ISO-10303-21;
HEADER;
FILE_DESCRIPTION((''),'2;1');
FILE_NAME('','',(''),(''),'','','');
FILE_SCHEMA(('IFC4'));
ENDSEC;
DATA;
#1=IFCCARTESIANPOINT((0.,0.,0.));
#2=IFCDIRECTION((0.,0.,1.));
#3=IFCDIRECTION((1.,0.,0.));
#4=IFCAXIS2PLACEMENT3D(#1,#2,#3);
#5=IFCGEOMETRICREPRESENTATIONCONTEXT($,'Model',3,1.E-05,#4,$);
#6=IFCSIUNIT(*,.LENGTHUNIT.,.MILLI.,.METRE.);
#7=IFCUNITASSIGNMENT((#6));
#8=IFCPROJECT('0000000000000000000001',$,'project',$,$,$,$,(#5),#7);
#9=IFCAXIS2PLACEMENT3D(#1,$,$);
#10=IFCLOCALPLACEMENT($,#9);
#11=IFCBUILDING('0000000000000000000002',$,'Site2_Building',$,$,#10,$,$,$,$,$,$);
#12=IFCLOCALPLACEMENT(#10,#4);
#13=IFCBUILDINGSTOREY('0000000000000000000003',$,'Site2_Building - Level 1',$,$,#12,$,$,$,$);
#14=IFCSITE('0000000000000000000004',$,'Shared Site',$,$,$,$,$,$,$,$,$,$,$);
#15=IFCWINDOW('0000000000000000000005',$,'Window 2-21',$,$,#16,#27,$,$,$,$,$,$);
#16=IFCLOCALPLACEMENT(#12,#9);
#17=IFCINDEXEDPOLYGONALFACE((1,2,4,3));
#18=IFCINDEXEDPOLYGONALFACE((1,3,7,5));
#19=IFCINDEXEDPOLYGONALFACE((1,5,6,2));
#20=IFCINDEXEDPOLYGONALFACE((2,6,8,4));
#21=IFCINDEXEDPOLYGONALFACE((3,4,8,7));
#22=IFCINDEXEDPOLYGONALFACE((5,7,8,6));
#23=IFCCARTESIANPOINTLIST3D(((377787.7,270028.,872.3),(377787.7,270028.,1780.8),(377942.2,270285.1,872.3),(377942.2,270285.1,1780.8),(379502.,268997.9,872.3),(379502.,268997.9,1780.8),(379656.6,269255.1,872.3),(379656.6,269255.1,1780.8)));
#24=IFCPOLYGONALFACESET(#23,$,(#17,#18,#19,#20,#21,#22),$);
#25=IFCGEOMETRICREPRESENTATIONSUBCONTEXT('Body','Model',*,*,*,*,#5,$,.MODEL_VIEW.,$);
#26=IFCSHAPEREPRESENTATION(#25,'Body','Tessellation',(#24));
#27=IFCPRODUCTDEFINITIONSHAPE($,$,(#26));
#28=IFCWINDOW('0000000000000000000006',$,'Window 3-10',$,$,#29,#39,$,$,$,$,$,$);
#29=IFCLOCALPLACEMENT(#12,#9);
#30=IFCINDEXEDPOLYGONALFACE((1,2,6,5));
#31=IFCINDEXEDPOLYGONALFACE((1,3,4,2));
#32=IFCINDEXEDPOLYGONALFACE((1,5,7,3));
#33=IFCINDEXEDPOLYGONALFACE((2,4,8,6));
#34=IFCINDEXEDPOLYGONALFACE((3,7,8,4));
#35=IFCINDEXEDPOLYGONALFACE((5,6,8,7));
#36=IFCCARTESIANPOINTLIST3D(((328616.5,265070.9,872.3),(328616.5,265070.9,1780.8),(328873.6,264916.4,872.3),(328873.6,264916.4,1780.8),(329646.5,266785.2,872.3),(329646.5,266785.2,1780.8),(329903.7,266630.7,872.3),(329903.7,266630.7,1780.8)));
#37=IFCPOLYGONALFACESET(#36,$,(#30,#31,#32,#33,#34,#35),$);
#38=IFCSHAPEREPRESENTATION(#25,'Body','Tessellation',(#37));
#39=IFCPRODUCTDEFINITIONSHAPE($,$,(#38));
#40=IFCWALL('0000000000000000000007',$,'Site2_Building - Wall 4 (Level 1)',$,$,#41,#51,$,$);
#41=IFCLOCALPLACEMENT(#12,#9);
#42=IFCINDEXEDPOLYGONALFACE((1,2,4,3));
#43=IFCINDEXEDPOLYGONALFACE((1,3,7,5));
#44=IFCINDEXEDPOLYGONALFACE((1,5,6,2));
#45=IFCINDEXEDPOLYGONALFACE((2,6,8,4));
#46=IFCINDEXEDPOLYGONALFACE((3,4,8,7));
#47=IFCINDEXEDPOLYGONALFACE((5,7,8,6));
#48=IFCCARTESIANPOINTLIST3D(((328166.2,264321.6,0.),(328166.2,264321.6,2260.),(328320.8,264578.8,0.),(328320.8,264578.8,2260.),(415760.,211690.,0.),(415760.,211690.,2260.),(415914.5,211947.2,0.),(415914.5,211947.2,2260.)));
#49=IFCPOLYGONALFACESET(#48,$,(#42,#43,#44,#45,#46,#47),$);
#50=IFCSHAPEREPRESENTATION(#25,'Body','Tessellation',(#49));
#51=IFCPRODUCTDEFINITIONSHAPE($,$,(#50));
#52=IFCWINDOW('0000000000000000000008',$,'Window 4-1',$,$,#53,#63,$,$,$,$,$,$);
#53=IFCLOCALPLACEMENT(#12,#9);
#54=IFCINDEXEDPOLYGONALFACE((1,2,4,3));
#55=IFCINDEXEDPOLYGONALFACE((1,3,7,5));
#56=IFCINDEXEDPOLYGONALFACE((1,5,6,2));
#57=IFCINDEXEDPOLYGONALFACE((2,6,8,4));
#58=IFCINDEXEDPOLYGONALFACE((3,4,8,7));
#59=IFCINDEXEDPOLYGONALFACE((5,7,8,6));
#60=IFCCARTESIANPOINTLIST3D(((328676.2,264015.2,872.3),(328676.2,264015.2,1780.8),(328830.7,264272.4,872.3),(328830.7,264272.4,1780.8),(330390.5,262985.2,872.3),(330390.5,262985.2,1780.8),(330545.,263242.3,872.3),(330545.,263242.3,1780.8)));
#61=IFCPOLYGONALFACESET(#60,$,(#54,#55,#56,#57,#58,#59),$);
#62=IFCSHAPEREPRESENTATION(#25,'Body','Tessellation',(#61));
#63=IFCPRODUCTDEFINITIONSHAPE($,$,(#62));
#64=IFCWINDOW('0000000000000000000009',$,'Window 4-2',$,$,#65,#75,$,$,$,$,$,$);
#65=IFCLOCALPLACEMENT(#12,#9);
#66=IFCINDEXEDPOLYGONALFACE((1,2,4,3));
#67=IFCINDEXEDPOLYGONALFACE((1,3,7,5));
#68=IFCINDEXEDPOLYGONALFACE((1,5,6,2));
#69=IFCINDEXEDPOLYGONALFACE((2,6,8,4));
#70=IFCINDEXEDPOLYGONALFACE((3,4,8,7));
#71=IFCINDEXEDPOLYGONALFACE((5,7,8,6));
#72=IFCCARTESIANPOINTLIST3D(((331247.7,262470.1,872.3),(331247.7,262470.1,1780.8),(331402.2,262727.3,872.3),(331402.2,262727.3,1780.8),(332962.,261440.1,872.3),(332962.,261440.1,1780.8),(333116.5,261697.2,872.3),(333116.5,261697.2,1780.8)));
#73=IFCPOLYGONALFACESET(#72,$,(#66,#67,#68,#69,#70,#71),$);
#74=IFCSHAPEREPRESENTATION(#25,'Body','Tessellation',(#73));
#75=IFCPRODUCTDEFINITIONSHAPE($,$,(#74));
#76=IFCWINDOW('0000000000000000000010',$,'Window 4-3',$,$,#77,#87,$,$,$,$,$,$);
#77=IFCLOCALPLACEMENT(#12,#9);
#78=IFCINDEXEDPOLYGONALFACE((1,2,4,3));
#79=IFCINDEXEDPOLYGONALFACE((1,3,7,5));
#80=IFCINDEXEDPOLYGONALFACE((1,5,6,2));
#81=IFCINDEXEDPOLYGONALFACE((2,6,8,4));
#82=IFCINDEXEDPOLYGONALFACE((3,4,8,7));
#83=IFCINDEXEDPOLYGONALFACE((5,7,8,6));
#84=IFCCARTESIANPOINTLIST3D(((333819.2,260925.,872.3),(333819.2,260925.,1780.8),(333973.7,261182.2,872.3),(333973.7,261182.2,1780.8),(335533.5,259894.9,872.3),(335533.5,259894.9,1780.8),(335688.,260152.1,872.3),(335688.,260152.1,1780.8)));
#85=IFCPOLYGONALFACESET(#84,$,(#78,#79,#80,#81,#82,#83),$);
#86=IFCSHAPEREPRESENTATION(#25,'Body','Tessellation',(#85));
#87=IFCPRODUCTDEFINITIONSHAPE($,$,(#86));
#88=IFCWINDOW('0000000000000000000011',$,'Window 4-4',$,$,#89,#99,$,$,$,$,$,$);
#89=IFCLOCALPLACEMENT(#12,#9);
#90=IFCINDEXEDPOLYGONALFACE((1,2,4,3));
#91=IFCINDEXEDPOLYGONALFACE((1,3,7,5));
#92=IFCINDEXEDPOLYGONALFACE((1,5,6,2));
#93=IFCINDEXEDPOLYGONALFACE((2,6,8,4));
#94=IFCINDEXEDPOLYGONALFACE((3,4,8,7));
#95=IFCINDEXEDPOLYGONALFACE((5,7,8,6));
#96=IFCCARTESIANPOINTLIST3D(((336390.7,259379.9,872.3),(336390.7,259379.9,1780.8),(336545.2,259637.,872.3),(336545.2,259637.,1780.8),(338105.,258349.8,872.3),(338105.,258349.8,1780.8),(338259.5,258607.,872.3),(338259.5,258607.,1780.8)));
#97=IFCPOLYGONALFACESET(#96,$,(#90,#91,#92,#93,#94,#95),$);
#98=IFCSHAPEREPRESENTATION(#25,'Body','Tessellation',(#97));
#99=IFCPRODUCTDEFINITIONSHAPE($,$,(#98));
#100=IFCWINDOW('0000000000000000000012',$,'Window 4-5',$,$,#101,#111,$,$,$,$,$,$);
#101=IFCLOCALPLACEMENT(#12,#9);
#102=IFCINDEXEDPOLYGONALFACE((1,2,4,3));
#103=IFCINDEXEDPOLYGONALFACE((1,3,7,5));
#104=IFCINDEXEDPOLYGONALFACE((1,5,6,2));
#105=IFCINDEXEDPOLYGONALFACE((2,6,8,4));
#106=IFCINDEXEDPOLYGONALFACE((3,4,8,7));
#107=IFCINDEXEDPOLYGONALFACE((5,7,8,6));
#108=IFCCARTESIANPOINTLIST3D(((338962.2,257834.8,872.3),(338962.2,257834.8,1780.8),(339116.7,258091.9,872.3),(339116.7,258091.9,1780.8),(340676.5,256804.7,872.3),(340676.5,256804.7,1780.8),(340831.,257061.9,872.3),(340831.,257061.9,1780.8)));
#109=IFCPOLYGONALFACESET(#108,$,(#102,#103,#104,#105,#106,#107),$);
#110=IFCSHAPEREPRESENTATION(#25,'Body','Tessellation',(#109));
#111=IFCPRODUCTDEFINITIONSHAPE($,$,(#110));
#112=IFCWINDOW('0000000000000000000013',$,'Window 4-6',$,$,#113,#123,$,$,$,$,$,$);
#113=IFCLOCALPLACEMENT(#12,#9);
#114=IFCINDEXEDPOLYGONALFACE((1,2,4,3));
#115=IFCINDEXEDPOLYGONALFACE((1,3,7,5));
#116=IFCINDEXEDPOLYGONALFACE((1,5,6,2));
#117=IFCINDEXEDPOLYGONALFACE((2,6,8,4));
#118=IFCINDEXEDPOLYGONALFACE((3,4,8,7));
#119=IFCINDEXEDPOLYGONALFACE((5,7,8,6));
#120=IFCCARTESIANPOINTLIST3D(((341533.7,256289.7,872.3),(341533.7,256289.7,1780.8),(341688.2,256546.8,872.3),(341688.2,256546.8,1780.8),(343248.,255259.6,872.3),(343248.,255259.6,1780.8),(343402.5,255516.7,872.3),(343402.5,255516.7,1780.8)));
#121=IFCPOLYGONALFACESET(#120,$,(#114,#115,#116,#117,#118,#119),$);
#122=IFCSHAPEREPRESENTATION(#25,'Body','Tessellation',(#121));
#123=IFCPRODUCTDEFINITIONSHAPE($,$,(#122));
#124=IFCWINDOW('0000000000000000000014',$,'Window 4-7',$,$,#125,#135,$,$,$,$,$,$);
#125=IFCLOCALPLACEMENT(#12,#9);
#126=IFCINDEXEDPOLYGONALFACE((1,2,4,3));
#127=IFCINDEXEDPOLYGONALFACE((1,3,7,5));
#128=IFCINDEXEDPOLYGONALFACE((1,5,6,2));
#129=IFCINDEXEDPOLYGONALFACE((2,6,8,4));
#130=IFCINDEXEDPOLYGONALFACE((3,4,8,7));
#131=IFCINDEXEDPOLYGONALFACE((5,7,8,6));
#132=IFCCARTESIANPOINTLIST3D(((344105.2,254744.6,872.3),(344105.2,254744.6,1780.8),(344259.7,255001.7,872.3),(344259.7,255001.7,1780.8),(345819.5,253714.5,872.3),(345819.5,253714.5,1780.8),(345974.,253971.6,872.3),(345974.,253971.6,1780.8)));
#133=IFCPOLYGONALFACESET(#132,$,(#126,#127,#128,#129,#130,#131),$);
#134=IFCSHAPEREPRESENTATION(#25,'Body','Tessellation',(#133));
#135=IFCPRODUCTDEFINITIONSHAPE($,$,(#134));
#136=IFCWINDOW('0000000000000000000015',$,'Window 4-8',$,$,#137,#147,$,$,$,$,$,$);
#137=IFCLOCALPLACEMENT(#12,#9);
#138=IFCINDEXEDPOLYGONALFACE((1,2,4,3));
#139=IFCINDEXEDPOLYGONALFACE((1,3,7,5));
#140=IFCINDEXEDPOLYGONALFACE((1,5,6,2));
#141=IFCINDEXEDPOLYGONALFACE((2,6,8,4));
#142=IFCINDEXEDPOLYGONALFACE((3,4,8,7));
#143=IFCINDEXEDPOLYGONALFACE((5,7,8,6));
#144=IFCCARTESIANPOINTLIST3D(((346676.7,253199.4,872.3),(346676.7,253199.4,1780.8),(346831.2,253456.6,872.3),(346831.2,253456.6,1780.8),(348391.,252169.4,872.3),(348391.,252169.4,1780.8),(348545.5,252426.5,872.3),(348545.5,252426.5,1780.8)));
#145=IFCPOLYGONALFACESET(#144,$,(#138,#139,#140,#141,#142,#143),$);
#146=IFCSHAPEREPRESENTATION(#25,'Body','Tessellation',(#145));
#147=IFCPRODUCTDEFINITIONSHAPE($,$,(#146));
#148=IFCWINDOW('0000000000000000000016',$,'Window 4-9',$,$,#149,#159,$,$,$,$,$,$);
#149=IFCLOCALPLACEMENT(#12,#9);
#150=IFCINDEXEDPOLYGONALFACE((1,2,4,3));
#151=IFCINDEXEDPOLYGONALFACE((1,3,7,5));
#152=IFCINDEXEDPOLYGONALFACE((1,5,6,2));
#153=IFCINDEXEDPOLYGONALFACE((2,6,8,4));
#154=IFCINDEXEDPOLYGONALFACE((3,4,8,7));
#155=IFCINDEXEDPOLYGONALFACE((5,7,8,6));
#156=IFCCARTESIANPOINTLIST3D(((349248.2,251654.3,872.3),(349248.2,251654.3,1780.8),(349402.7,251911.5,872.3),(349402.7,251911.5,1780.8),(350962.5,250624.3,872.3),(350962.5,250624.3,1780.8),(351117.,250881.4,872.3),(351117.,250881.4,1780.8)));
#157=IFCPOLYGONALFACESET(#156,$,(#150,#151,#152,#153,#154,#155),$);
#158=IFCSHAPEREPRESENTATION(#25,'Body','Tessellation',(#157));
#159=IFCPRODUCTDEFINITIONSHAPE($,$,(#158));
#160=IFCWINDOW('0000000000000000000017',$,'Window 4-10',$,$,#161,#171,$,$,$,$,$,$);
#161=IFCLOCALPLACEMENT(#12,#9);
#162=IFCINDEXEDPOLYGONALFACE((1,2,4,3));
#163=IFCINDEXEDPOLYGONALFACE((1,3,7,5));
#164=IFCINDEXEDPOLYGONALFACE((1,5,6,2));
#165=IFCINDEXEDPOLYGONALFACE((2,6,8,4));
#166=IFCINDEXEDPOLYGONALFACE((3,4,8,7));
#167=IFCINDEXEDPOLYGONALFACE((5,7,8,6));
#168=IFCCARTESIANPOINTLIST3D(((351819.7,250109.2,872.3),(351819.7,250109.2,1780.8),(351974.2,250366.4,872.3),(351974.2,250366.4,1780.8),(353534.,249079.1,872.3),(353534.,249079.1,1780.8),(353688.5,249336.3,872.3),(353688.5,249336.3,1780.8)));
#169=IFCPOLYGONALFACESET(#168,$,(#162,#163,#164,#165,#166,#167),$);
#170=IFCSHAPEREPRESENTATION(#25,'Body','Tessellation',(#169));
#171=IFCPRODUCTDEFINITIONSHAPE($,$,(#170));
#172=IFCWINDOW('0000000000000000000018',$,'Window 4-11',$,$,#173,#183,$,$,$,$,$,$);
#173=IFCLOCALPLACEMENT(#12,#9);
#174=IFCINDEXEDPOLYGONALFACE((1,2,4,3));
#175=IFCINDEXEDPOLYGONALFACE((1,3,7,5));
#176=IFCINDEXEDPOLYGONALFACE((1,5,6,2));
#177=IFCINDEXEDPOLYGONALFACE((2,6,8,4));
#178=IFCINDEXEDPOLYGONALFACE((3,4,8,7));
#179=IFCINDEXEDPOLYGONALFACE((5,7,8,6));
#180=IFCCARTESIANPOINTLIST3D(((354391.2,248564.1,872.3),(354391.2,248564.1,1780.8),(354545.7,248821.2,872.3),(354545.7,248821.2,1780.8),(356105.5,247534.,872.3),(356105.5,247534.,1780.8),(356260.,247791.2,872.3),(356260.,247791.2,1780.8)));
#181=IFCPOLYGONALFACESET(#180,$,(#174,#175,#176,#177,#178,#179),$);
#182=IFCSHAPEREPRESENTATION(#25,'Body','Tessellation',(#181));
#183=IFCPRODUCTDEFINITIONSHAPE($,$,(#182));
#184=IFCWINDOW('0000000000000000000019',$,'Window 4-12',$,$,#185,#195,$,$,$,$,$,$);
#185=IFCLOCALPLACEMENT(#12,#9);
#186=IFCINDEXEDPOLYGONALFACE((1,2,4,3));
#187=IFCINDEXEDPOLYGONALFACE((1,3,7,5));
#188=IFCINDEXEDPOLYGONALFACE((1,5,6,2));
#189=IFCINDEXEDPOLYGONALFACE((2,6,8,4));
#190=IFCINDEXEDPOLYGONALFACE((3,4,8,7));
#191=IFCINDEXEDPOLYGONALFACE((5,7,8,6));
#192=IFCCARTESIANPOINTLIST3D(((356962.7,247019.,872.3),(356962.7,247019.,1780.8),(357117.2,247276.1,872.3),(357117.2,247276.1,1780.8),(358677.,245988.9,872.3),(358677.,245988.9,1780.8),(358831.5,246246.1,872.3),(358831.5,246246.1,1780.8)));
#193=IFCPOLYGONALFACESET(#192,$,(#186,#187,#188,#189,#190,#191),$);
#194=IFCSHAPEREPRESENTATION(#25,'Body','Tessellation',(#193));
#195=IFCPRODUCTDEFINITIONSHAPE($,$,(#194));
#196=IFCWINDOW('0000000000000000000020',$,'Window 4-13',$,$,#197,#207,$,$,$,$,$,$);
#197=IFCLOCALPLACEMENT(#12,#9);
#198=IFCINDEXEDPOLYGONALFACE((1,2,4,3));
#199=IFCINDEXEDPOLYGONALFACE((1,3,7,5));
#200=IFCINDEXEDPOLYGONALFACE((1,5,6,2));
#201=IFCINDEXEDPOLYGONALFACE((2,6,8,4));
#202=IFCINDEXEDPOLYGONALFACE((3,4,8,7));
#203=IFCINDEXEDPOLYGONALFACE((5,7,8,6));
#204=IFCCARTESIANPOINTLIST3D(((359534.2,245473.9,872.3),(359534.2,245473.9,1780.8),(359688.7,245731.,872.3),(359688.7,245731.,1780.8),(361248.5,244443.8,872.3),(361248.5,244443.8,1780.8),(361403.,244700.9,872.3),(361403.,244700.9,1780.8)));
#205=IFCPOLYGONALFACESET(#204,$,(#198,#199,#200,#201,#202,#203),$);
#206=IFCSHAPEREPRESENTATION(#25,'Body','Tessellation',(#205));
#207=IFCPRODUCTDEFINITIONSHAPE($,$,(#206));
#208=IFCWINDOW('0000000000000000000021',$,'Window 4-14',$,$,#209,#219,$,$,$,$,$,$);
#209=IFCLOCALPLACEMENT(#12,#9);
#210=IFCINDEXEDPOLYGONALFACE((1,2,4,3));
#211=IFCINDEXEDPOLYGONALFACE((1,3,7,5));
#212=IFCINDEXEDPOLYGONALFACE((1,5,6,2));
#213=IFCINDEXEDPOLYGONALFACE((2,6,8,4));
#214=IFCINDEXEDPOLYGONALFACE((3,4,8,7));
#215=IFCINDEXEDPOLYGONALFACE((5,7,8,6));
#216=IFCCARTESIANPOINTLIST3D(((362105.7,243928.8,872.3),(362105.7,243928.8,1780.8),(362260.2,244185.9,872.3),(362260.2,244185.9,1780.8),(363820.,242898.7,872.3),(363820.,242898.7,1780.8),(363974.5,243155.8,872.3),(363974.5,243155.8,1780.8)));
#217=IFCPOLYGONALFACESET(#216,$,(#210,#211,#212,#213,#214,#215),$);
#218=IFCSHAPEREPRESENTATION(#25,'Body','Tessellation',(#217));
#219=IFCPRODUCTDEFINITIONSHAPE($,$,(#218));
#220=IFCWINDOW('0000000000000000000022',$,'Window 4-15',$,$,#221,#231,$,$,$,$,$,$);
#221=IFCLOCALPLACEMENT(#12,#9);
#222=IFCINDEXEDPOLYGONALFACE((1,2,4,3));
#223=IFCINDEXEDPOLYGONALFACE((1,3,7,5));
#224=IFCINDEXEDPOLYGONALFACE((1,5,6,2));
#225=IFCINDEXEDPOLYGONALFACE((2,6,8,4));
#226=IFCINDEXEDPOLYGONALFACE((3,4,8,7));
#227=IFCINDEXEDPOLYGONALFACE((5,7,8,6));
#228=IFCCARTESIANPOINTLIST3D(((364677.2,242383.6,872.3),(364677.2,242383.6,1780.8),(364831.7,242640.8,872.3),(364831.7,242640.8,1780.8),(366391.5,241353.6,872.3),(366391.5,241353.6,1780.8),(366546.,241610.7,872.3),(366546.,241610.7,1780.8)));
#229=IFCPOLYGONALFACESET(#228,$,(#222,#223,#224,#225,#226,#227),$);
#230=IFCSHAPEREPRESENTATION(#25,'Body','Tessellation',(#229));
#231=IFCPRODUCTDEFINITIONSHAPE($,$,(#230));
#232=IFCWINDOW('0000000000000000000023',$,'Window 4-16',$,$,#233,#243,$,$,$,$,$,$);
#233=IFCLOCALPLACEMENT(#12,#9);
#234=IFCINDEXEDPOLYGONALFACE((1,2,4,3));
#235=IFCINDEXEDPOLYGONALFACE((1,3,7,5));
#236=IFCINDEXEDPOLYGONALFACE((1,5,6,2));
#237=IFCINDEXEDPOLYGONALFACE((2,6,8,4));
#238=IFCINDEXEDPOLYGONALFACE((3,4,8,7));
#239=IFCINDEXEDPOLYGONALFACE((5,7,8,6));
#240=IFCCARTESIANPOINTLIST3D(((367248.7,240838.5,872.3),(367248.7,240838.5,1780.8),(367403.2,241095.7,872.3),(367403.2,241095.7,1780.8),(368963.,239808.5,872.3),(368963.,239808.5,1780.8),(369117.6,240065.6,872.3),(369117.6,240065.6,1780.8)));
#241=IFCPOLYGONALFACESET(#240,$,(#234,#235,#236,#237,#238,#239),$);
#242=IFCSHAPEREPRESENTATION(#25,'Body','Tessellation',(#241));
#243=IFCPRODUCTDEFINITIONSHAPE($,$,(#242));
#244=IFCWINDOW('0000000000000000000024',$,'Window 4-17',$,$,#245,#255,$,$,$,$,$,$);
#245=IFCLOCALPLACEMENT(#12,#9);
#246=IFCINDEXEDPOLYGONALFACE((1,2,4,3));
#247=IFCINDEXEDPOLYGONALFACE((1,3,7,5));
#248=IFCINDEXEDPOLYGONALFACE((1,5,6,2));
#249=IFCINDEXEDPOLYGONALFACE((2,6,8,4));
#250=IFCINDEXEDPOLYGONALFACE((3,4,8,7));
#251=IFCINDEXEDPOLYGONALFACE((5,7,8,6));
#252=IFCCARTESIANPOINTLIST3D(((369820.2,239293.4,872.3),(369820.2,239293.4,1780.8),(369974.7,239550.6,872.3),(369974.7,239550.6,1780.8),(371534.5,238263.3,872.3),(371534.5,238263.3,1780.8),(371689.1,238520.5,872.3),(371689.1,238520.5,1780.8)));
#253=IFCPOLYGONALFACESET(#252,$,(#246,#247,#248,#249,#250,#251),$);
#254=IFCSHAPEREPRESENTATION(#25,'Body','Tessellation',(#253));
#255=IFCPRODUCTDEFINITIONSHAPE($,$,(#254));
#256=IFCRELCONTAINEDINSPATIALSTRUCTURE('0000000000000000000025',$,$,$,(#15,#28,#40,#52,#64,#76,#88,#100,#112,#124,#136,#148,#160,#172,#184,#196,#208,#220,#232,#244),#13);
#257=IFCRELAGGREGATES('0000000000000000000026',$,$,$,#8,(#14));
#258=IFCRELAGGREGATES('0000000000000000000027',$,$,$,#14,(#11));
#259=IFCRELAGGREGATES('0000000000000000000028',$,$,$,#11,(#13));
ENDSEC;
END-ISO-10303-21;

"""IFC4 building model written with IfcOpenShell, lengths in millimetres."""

from ifc_helpers import new_model, si_unit, frame, origin, origin_with_axes, place, context, subcontext, project, spatial, indexed_curve, outline, extrude, element, save


model = new_model("IFC4")

# Units and contexts
model_context = context("Model", 3, precision=1e-05, world=origin_with_axes())
body_context = subcontext(model_context, "Body", "Model", "MODEL_VIEW")
ifc_project = project(units=[si_unit("LENGTHUNIT", "METRE", prefix="MILLI")], contexts=[model_context])

# Site, building, storey
site = spatial("IfcSite", under=ifc_project, Name="Shared Site")
building_placement = place(None, origin())
building = spatial("IfcBuilding", under=site, at=building_placement, Name="Site2_Building")
storey_placement = place(building_placement, origin_with_axes())
storey = spatial("IfcBuildingStorey", under=building, at=storey_placement, Name="Site2_Building - Level 1")

# Windows
for number, where, z_axis, x_axis, name in (
    (1, (379656.6, 269255.1, 872.3), (0.0, 0.0, 1.0), (-0.857167, 0.515038, 0.0), "Window 2-21"),
    (2, (329646.5, 266785.2, 872.3), (0.0, 0.0, 1.0), (-0.515038, -0.857167, 0.0), "Window 3-10"),
):
    element("IfcWindow", number, at=place(storey_placement, frame(where, z_axis=z_axis, x_axis=x_axis)), inside=storey, Name=name, context=body_context, shape_type="SweptSolid", body=[
        extrude(outline(indexed_curve([(0.0, 0.0), (0.0, 300.0), (2000.0, 300.0), (2000.0, 0.0), (0.0, 0.0)], self_intersect=False)), origin_with_axes(), (0.0, 0.0, 1.0), 908.6),
    ])

# Wall
wall_placement = place(storey_placement, frame((328166.2, 264321.6, 0.0), z_axis=(0.0, 0.0, 1.0), x_axis=(0.857167, -0.515038, 0.0)))
element("IfcWall", 3, at=wall_placement, inside=storey, Name="Site2_Building - Wall 4 (Level 1)", context=body_context, shape_type="SweptSolid", body=[
    extrude(outline(indexed_curve([(0.0, 0.0), (0.0, 300.0), (102189.8, 300.0), (102189.8, 0.0), (0.0, 0.0)], self_intersect=False)), origin_with_axes(), (0.0, 0.0, 1.0), 2260.0),
])

# Windows
for number, where, z_axis, x_axis, name in (
    (4, (328676.2, 264015.2, 872.3), (0.0, 0.0, 1.0), (0.857167, -0.515038, 0.0), "Window 4-1"),
    (5, (331247.7, 262470.1, 872.3), (0.0, 0.0, 1.0), (0.857167, -0.515038, 0.0), "Window 4-2"),
    (6, (333819.2, 260925.0, 872.3), (0.0, 0.0, 1.0), (0.857167, -0.515038, 0.0), "Window 4-3"),
    (7, (336390.7, 259379.9, 872.3), (0.0, 0.0, 1.0), (0.857167, -0.515038, 0.0), "Window 4-4"),
    (8, (338962.2, 257834.8, 872.3), (0.0, 0.0, 1.0), (0.857167, -0.515038, 0.0), "Window 4-5"),
    (9, (341533.7, 256289.7, 872.3), (0.0, 0.0, 1.0), (0.857167, -0.515038, 0.0), "Window 4-6"),
    (10, (344105.2, 254744.6, 872.3), (0.0, 0.0, 1.0), (0.857167, -0.515038, 0.0), "Window 4-7"),
    (11, (346676.7, 253199.4, 872.3), (0.0, 0.0, 1.0), (0.857167, -0.515038, 0.0), "Window 4-8"),
    (12, (349248.2, 251654.3, 872.3), (0.0, 0.0, 1.0), (0.857167, -0.515038, 0.0), "Window 4-9"),
    (13, (351819.7, 250109.2, 872.3), (0.0, 0.0, 1.0), (0.857167, -0.515038, 0.0), "Window 4-10"),
    (14, (354391.2, 248564.1, 872.3), (0.0, 0.0, 1.0), (0.857167, -0.515038, 0.0), "Window 4-11"),
    (15, (356962.7, 247019.0, 872.3), (0.0, 0.0, 1.0), (0.857167, -0.515038, 0.0), "Window 4-12"),
    (16, (359534.2, 245473.9, 872.3), (0.0, 0.0, 1.0), (0.857167, -0.515038, 0.0), "Window 4-13"),
    (17, (362105.7, 243928.8, 872.3), (0.0, 0.0, 1.0), (0.857167, -0.515038, 0.0), "Window 4-14"),
    (18, (364677.2, 242383.6, 872.3), (0.0, 0.0, 1.0), (0.857167, -0.515038, 0.0), "Window 4-15"),
    (19, (367248.7, 240838.5, 872.3), (0.0, 0.0, 1.0), (0.857167, -0.515038, 0.0), "Window 4-16"),
    (20, (369820.2, 239293.4, 872.3), (0.0, 0.0, 1.0), (0.857167, -0.515038, 0.0), "Window 4-17"),
):
    element("IfcWindow", number, at=place(storey_placement, frame(where, z_axis=z_axis, x_axis=x_axis)), inside=storey, Name=name, context=body_context, shape_type="SweptSolid", body=[
        extrude(outline(indexed_curve([(0.0, 0.0), (0.0, 300.0), (2000.0, 300.0), (2000.0, 0.0), (0.0, 0.0)], self_intersect=False)), origin_with_axes(), (0.0, 0.0, 1.0), 908.6),
    ])

save(model, "model.ifc")
